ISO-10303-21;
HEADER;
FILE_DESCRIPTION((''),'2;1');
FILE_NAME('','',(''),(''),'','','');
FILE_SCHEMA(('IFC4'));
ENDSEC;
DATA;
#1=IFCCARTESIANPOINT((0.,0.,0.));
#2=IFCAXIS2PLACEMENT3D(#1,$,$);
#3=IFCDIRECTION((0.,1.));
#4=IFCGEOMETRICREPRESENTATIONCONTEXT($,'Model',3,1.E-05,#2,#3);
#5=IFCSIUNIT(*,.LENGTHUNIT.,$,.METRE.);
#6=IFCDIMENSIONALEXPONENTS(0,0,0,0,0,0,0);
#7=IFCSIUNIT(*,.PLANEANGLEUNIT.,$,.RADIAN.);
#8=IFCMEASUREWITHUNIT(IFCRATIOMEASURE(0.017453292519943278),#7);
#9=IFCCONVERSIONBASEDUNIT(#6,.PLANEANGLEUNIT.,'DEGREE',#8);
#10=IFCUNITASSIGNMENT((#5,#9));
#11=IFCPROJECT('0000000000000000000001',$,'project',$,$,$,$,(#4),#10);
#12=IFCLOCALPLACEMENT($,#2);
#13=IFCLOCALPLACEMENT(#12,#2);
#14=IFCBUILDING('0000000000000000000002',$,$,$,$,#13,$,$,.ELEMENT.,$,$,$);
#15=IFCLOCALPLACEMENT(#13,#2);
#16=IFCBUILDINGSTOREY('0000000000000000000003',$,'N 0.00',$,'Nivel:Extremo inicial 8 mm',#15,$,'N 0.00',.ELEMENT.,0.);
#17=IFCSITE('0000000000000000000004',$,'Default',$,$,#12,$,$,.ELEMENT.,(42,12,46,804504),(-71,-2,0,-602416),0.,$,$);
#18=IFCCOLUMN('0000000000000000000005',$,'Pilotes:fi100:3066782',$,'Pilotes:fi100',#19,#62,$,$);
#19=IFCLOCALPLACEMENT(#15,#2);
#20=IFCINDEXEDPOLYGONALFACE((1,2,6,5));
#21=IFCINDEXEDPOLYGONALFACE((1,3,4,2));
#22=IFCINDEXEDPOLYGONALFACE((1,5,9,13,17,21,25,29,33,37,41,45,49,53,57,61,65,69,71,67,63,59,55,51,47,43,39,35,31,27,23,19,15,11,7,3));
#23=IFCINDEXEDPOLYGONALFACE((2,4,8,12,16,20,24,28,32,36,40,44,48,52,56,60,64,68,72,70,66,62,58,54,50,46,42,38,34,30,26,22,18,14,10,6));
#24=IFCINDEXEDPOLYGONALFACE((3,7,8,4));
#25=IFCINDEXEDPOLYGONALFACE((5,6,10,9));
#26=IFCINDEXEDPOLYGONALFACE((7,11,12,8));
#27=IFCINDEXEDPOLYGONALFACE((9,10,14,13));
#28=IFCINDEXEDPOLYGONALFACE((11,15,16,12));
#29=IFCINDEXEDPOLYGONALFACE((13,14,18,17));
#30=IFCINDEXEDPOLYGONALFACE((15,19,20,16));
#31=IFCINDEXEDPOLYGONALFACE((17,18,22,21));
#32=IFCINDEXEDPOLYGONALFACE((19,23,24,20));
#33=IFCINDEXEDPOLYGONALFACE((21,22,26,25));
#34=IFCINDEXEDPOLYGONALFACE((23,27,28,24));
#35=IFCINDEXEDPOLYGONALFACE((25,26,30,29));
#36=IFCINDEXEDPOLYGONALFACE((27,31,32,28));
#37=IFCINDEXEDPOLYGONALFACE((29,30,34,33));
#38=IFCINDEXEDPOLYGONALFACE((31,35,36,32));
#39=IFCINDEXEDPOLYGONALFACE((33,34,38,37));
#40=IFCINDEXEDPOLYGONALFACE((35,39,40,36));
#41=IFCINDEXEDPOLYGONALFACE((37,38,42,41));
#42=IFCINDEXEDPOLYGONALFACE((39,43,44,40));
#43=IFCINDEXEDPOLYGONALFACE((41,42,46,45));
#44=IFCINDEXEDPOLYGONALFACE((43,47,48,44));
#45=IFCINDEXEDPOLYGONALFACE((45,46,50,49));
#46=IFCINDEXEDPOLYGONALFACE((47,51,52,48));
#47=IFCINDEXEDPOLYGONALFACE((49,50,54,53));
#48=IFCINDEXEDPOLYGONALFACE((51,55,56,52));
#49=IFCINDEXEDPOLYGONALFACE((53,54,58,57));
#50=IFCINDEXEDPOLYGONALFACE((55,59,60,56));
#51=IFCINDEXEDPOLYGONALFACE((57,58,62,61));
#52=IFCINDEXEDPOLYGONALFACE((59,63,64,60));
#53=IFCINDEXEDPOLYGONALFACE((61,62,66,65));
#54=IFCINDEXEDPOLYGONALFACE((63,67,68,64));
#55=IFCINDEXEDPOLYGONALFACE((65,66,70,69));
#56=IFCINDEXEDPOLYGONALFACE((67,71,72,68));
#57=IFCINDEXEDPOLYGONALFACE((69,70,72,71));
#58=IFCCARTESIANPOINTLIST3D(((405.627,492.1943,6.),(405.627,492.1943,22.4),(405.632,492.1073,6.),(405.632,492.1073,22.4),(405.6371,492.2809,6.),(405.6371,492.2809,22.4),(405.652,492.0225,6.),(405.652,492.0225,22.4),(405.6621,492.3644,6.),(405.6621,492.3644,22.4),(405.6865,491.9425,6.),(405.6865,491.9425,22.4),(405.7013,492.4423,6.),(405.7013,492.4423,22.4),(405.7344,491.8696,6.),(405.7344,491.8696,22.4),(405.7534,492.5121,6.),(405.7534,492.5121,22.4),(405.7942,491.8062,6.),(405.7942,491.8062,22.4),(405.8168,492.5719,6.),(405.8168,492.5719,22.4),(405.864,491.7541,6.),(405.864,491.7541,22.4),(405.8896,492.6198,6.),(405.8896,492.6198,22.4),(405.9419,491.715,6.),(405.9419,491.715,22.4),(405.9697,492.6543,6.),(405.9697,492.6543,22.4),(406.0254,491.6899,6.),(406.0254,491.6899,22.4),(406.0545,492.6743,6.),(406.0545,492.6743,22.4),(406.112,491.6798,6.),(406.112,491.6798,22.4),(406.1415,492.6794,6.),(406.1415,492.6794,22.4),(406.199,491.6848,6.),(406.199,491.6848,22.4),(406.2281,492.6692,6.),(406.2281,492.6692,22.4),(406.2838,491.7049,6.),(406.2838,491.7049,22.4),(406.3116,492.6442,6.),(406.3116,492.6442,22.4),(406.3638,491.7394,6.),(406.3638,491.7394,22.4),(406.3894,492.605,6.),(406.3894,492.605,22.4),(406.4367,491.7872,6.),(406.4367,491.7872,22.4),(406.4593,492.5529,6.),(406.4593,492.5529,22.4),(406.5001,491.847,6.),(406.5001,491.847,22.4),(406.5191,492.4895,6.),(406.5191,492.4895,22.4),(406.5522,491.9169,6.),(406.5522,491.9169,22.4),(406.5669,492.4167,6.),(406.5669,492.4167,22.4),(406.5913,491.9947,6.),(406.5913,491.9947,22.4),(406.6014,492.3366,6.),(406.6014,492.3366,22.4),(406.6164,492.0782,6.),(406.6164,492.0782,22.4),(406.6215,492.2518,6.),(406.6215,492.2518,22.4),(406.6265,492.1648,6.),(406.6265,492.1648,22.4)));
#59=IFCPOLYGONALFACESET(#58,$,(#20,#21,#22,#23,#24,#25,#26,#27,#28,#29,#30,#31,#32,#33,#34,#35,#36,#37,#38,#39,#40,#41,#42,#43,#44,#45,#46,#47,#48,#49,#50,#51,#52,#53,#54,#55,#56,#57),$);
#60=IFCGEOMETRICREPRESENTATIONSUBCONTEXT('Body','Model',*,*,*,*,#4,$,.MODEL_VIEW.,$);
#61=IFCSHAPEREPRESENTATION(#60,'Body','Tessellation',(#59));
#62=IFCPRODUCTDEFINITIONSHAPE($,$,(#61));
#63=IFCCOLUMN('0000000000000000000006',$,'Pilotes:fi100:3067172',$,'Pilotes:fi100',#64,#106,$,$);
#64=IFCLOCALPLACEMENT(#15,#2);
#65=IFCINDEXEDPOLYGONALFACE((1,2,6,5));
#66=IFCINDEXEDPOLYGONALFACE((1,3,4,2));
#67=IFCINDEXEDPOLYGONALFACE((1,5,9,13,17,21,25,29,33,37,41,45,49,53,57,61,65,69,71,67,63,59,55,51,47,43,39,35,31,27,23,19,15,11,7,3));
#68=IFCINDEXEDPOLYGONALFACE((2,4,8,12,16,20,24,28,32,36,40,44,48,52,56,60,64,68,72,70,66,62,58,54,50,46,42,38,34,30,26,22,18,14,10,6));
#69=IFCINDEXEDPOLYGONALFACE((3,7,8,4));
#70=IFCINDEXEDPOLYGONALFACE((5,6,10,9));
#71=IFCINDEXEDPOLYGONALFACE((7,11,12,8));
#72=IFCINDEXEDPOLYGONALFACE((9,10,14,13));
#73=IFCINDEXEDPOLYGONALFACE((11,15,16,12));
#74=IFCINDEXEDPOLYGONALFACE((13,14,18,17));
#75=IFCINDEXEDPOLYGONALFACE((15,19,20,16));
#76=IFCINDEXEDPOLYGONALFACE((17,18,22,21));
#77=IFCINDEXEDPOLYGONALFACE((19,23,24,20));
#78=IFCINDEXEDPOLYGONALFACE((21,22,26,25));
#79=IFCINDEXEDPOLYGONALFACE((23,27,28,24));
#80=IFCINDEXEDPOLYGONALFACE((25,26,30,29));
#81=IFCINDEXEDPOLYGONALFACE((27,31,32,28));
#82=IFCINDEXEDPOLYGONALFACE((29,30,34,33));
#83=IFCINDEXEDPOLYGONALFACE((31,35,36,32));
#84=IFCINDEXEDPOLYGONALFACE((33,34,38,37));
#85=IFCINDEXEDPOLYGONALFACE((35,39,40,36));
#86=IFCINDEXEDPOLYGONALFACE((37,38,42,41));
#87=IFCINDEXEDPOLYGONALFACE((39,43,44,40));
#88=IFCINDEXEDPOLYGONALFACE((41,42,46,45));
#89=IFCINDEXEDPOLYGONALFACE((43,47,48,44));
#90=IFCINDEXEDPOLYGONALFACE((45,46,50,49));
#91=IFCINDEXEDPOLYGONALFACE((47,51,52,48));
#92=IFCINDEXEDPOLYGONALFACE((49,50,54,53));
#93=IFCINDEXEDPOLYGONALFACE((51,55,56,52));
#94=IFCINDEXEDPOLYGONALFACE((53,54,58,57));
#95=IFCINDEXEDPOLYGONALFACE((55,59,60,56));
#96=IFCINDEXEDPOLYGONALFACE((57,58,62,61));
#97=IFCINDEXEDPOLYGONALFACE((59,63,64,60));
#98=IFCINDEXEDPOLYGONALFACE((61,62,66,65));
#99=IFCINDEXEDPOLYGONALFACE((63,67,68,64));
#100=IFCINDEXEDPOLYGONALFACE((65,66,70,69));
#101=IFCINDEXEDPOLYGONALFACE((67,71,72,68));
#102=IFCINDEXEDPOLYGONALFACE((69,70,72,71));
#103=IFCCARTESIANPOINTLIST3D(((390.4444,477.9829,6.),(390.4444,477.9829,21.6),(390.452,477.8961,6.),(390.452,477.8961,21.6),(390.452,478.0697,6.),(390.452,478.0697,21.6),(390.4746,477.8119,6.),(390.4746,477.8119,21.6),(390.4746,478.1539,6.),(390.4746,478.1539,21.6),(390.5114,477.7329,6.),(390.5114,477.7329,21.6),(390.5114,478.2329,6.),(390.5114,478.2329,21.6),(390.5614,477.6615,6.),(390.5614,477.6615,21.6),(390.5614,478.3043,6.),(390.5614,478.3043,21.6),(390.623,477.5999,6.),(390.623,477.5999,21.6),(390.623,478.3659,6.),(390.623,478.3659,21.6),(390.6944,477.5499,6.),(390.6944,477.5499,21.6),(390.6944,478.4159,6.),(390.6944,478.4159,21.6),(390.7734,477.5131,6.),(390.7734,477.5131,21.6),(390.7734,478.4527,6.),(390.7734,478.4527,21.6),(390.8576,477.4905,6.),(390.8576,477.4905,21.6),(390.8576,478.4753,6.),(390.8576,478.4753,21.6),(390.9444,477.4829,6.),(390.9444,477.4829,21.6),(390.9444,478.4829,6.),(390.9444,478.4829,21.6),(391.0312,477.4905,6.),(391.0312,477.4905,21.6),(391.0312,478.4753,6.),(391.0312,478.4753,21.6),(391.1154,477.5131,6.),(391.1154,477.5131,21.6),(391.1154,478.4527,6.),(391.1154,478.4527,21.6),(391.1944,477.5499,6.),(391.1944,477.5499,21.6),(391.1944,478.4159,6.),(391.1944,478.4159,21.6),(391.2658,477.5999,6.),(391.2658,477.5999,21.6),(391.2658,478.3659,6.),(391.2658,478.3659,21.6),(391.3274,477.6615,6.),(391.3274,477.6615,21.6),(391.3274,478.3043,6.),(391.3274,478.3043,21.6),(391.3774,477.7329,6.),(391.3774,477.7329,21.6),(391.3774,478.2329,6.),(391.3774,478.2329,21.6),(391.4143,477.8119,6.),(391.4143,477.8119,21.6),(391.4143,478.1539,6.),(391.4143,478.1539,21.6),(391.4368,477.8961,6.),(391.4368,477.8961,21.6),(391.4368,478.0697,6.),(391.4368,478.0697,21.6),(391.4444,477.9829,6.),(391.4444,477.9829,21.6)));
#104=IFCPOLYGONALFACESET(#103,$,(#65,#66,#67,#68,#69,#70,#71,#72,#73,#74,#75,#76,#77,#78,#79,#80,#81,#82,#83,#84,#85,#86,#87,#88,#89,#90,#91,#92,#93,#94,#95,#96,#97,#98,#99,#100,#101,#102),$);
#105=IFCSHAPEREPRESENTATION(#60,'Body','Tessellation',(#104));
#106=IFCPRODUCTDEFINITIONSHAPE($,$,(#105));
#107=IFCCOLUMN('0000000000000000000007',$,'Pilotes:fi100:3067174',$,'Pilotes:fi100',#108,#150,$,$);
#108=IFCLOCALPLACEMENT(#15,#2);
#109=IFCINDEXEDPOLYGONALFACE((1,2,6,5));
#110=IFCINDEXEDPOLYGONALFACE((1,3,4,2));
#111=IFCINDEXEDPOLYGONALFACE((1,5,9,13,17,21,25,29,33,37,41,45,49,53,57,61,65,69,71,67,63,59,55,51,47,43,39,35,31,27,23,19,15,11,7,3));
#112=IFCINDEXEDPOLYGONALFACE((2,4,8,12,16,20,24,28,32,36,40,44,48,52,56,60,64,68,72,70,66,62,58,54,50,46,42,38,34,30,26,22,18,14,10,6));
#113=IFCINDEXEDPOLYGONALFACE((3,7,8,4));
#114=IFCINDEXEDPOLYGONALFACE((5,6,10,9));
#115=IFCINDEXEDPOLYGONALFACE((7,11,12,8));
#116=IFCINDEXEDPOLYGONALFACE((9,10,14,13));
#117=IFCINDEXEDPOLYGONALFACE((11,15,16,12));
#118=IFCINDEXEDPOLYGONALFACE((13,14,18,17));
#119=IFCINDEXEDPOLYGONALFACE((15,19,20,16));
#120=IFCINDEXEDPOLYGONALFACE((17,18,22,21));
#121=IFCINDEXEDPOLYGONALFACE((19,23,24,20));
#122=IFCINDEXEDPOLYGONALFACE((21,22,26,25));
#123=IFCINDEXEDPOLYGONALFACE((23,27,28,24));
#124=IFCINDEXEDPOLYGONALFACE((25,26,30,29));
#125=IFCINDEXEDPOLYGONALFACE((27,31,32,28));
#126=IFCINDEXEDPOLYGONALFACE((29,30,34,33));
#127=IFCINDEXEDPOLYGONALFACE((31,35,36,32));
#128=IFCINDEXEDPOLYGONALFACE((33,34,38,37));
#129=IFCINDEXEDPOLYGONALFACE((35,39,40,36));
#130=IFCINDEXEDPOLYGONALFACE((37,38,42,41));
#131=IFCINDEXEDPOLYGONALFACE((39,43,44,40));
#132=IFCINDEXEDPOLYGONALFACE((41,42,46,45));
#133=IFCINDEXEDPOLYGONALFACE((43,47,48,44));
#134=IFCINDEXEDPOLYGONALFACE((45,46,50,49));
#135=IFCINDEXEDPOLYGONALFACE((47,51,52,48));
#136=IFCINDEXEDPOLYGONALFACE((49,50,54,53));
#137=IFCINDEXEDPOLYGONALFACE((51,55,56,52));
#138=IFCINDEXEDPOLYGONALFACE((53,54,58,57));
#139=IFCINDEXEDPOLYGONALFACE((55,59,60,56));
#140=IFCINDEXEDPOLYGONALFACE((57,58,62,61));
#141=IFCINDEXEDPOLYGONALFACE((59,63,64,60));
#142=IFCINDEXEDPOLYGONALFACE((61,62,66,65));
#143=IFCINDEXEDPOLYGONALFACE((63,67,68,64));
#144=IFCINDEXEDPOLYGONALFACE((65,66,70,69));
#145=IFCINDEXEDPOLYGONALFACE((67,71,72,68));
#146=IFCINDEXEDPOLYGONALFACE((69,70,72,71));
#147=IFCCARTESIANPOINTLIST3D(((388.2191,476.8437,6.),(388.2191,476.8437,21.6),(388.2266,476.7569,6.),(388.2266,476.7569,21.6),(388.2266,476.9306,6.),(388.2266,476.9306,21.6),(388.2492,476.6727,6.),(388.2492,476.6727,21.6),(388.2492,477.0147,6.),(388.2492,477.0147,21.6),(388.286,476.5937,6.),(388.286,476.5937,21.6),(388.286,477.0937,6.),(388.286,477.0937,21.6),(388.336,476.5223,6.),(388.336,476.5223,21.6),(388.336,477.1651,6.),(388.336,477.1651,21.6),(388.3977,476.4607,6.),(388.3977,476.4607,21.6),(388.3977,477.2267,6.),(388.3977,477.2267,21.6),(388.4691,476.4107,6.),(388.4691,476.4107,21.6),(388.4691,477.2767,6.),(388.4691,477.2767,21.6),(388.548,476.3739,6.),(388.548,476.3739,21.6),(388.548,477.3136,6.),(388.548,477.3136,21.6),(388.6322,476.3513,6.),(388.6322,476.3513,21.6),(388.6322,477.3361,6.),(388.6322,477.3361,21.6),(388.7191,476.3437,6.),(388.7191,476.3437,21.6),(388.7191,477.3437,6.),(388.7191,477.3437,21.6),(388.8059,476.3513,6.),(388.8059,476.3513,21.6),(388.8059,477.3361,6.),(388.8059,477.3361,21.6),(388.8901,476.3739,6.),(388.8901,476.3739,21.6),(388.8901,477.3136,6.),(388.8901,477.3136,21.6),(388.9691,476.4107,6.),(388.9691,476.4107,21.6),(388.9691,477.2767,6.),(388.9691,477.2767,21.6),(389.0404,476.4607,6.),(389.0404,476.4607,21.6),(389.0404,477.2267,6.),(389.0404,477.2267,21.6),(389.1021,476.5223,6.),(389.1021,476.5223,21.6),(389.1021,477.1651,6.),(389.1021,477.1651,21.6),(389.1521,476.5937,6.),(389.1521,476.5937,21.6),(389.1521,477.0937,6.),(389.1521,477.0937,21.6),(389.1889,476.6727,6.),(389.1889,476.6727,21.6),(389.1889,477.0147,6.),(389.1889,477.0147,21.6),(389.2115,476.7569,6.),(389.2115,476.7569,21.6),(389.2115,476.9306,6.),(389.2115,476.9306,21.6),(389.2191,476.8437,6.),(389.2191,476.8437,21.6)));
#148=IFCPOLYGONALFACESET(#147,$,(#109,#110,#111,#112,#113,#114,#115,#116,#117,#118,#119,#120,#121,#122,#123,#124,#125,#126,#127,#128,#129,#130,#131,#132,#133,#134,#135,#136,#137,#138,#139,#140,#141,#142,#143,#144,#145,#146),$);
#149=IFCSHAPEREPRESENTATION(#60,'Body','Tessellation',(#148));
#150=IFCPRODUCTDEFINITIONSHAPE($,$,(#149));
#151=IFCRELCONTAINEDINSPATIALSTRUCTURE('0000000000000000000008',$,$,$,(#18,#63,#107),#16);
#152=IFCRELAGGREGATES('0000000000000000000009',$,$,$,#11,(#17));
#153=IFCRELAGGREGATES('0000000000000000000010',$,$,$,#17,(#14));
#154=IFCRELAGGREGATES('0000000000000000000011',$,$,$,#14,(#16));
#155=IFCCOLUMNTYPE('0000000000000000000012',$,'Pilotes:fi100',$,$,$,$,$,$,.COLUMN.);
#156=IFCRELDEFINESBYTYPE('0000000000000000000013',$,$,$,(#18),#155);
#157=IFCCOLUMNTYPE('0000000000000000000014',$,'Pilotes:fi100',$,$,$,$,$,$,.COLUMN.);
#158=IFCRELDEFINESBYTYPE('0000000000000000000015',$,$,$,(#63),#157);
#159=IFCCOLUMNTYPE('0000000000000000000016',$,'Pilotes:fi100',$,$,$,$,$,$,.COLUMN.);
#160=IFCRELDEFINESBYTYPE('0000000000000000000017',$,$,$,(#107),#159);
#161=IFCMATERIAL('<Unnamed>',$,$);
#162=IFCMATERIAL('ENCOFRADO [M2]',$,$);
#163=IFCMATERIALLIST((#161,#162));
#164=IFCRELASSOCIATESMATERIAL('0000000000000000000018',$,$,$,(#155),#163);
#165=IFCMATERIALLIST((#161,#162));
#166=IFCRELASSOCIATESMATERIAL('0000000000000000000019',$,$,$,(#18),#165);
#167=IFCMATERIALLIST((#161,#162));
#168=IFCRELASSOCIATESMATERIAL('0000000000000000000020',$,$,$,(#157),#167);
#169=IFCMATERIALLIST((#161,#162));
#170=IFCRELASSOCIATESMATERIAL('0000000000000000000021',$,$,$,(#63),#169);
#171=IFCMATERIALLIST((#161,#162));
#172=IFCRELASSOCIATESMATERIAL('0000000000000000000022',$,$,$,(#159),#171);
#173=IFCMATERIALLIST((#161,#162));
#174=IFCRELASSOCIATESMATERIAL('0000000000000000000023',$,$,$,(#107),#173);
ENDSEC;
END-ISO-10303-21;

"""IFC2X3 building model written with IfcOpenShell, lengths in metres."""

from ifc_helpers import new_model, entity, si_unit, converted_unit, direction, frame, frame_2d, origin, place, context, subcontext, project, spatial, circle, extrude, source, transform, mapped, material, material_list, type_object, type_shapes, element, save


model = new_model("IFC2X3")

# Units and contexts
model_context = context("Model", 3, precision=1e-05, world=origin(), true_north=direction((0.0, 1.0)))
body_context = subcontext(model_context, "Body", "Model", "MODEL_VIEW")
ifc_project = project(units=[si_unit("LENGTHUNIT", "METRE"), converted_unit("PLANEANGLEUNIT", "DEGREE", entity("IfcRatioMeasure", 0.017453292519943278), si_unit("PLANEANGLEUNIT", "RADIAN"), dimensions=[0, 0, 0, 0, 0, 0, 0])], contexts=[model_context])

# Site, building, storey
site_placement = place(None, origin())
site = spatial("IfcSite", under=ifc_project, at=site_placement, Name="Default", CompositionType="ELEMENT", RefLatitude=(42, 12, 46, 804504), RefLongitude=(-71, -2, 0, -602416), RefElevation=0.0)
building_placement = place(site_placement, origin())
building = spatial("IfcBuilding", under=site, at=building_placement, CompositionType="ELEMENT")
storey_placement = place(building_placement, origin())
storey = spatial("IfcBuildingStorey", under=building, at=storey_placement, Name="N 0.00", ObjectType="Nivel:Extremo inicial 8 mm", LongName="N 0.00", CompositionType="ELEMENT", Elevation=0.0)

# Columns
ifc_material_1 = material(Name="<Unnamed>")
ifc_material_2 = material(Name="ENCOFRADO [M2]")
ifc_material_list_1 = material_list([ifc_material_1, ifc_material_2])
ifc_material_list_2 = material_list([ifc_material_1, ifc_material_2])
column_type_1 = type_object("IfcColumnType", Name="Pilotes:fi100", PredefinedType="COLUMN", material=ifc_material_list_2)
shared_shape_1 = source(origin(), body_context, "Body", "SweptSolid", [
    extrude(circle(Radius=0.5, at=frame_2d((0.0, 0.1667), x_axis=(1.0, 0.0))), frame((406.1317, 492.3462, 6.0), z_axis=(0.0, 0.0, 1.0), x_axis=(-0.999563, 0.029559, 0.0)), (0.0, 0.0, 1.0), 16.4),
])
type_shapes(column_type_1, [shared_shape_1])
column_1_placement = place(storey_placement, origin())
element("IfcColumn", 1, at=column_1_placement, inside=storey, type_object=column_type_1, material=ifc_material_list_1, Name="Pilotes:fi100:3066782", ObjectType="Pilotes:fi100", context=body_context, shape_type="MappedRepresentation", body=[
    mapped(shared_shape_1, transform((0.0, 0.0, 0.0), scale=1.0)),
])
ifc_material_list_3 = material_list([ifc_material_1, ifc_material_2])
ifc_material_list_4 = material_list([ifc_material_1, ifc_material_2])
column_type_2 = type_object("IfcColumnType", Name="Pilotes:fi100", PredefinedType="COLUMN", material=ifc_material_list_4)
shared_shape_2 = source(origin(), body_context, "Body", "SweptSolid", [
    extrude(circle(Radius=0.5, at=frame_2d((0.0, 0.1667), x_axis=(1.0, 0.0))), frame((390.9444, 478.1496, 6.0), z_axis=(0.0, 0.0, 1.0), x_axis=(-1.0, 0.0, 0.0)), (0.0, 0.0, 1.0), 15.6),
])
type_shapes(column_type_2, [shared_shape_2])
column_2_placement = place(storey_placement, origin())
element("IfcColumn", 2, at=column_2_placement, inside=storey, type_object=column_type_2, material=ifc_material_list_3, Name="Pilotes:fi100:3067172", ObjectType="Pilotes:fi100", context=body_context, shape_type="MappedRepresentation", body=[
    mapped(shared_shape_2, transform((0.0, 0.0, 0.0), scale=1.0)),
])
ifc_material_list_5 = material_list([ifc_material_1, ifc_material_2])
ifc_material_list_6 = material_list([ifc_material_1, ifc_material_2])
column_type_3 = type_object("IfcColumnType", Name="Pilotes:fi100", PredefinedType="COLUMN", material=ifc_material_list_6)
shared_shape_3 = source(origin(), body_context, "Body", "SweptSolid", [
    extrude(circle(Radius=0.5, at=frame_2d((0.0, 0.1667), x_axis=(1.0, 0.0))), frame((388.7191, 477.0104, 6.0), z_axis=(0.0, 0.0, 1.0), x_axis=(-1.0, 0.0, 0.0)), (0.0, 0.0, 1.0), 15.6),
])
type_shapes(column_type_3, [shared_shape_3])
column_3_placement = place(storey_placement, origin())
element("IfcColumn", 3, at=column_3_placement, inside=storey, type_object=column_type_3, material=ifc_material_list_5, Name="Pilotes:fi100:3067174", ObjectType="Pilotes:fi100", context=body_context, shape_type="MappedRepresentation", body=[
    mapped(shared_shape_3, transform((0.0, 0.0, 0.0), scale=1.0)),
])

save(model, "model.ifc")
